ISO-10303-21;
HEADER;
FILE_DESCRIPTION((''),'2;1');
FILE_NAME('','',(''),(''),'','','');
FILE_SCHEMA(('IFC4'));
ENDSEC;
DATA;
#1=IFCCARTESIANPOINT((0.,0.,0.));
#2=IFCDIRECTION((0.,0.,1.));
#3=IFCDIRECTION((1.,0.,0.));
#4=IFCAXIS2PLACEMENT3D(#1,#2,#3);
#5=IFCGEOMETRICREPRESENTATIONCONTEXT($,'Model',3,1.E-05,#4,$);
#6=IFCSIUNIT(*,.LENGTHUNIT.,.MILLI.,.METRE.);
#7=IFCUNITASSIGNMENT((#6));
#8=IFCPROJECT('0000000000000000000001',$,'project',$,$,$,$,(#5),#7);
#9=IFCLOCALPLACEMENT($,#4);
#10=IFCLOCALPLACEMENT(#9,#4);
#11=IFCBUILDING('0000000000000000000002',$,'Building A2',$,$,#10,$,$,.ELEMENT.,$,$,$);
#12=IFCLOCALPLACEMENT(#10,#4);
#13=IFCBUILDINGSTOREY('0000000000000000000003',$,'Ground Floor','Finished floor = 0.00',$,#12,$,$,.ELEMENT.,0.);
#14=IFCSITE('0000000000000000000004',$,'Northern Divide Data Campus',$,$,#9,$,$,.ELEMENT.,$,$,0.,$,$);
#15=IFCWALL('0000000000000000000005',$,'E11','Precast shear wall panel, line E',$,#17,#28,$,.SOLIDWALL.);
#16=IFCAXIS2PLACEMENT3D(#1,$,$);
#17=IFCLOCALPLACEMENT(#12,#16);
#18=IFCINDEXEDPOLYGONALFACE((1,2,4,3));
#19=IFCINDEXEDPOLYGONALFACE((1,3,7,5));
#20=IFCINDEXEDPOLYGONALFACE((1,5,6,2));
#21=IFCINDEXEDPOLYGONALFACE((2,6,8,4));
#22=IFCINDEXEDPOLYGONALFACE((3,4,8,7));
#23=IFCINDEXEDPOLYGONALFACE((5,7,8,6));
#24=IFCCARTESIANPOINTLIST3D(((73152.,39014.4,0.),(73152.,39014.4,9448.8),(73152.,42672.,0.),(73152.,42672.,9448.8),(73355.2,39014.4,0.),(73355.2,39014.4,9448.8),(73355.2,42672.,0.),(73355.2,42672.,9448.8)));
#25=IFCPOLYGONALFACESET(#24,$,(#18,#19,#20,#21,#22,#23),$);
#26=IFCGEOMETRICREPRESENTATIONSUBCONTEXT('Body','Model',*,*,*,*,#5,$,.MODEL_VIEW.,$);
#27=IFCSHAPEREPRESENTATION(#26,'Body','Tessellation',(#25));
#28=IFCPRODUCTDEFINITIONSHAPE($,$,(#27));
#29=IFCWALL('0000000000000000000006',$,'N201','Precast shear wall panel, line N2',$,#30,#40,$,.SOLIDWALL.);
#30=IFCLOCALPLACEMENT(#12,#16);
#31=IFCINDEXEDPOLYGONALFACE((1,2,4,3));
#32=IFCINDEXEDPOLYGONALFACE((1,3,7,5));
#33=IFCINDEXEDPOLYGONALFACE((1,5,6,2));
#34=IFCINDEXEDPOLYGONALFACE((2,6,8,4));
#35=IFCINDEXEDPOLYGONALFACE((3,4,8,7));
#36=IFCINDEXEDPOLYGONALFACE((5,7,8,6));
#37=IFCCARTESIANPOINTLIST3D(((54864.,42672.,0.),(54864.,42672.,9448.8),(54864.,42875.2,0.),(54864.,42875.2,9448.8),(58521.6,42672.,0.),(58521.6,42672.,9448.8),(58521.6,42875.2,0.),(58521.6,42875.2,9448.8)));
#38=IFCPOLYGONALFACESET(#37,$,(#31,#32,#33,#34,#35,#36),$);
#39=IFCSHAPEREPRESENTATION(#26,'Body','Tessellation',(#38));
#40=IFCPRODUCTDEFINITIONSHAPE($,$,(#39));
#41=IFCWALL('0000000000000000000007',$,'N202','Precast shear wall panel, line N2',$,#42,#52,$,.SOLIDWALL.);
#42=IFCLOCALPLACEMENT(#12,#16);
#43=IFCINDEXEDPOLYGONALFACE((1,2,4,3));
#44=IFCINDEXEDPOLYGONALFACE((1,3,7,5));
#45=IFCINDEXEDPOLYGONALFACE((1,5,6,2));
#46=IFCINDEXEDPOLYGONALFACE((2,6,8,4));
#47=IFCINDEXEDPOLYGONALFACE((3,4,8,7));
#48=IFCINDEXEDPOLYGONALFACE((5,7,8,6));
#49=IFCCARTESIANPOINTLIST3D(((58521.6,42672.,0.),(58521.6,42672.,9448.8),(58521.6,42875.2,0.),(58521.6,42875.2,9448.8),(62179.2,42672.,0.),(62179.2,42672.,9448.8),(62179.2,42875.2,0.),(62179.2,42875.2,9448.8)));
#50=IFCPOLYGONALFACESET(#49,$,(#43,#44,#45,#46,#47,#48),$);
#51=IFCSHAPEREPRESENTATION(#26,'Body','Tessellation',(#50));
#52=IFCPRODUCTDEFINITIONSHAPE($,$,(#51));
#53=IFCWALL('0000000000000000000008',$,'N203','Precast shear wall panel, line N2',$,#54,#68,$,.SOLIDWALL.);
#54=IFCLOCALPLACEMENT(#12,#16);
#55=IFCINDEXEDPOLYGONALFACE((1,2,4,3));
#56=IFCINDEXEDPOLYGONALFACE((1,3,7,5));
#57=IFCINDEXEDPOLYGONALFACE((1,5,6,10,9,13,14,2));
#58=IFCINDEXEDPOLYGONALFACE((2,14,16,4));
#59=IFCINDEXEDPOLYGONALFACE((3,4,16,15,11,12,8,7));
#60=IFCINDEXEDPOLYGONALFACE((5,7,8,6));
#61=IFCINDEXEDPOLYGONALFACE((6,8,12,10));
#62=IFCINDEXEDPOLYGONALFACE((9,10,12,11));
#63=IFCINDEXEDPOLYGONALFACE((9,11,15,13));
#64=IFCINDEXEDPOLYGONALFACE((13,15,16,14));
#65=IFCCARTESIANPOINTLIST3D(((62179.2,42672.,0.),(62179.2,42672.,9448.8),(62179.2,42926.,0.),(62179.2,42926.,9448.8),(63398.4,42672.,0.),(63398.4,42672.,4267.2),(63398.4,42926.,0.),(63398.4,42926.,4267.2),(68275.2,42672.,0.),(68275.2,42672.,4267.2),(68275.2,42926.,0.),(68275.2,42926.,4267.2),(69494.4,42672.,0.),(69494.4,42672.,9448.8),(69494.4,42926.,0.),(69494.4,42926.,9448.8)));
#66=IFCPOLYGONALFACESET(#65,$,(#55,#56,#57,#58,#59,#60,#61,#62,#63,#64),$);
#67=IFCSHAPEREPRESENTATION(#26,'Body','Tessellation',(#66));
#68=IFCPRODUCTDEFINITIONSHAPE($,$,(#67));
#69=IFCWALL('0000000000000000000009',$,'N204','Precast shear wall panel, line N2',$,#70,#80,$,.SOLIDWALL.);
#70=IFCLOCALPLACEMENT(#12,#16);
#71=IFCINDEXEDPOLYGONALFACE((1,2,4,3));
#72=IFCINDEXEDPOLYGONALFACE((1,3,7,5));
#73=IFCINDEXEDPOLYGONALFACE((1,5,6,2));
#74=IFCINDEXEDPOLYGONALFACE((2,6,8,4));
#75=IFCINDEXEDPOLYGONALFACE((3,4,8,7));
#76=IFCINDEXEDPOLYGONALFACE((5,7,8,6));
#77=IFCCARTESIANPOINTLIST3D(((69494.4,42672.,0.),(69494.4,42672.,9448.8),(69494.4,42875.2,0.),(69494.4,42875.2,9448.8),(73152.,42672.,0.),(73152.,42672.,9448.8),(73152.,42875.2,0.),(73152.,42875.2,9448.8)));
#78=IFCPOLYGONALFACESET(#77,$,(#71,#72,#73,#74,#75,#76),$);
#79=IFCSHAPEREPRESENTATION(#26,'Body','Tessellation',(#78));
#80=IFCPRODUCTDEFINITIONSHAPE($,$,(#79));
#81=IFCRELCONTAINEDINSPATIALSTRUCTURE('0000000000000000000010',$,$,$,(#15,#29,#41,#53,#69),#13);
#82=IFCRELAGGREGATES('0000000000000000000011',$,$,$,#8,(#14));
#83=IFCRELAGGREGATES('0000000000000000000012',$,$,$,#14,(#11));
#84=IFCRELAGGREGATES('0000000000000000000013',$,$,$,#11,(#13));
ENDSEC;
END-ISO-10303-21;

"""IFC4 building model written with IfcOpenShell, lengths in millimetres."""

from ifc_helpers import new_model, si_unit, origin, origin_with_axes, place, context, subcontext, project, spatial, polyline, outline, extrude, element, save


model = new_model("IFC4")

# Units and contexts
model_context = context("Model", 3, precision=1e-05, world=origin_with_axes())
body_context = subcontext(model_context, "Body", "Model", "MODEL_VIEW")
ifc_project = project(units=[si_unit("LENGTHUNIT", "METRE", prefix="MILLI")], contexts=[model_context])

# Site, building, storey
site_placement = place(None, origin_with_axes())
site = spatial("IfcSite", under=ifc_project, at=site_placement, Name="Northern Divide Data Campus", CompositionType="ELEMENT", RefElevation=0.0)
building_placement = place(site_placement, origin_with_axes())
building = spatial("IfcBuilding", under=site, at=building_placement, Name="Building A2", CompositionType="ELEMENT")
storey_placement = place(building_placement, origin_with_axes())
storey = spatial("IfcBuildingStorey", under=building, at=storey_placement, Name="Ground Floor", Description="Finished floor = 0.00", CompositionType="ELEMENT", Elevation=0.0)

# Walls
wall_1_placement = place(storey_placement, origin_with_axes())
element("IfcWall", 1, at=wall_1_placement, inside=storey, Name="E11", Description="Precast shear wall panel, line E", PredefinedType="SOLIDWALL", context=body_context, shape_type="SweptSolid", body=[
    extrude(outline(polyline([(73152.0, 39014.4), (73355.2, 39014.4), (73355.2, 42672.0), (73152.0, 42672.0), (73152.0, 39014.4)])), origin(), (0.0, 0.0, 1.0), 9448.8),
])
wall_2_placement = place(storey_placement, origin_with_axes())
element("IfcWall", 2, at=wall_2_placement, inside=storey, Name="N201", Description="Precast shear wall panel, line N2", PredefinedType="SOLIDWALL", context=body_context, shape_type="SweptSolid", body=[
    extrude(outline(polyline([(54864.0, 42672.0), (58521.6, 42672.0), (58521.6, 42875.2), (54864.0, 42875.2), (54864.0, 42672.0)])), origin(), (0.0, 0.0, 1.0), 9448.8),
])
wall_3_placement = place(storey_placement, origin_with_axes())
element("IfcWall", 3, at=wall_3_placement, inside=storey, Name="N202", Description="Precast shear wall panel, line N2", PredefinedType="SOLIDWALL", context=body_context, shape_type="SweptSolid", body=[
    extrude(outline(polyline([(58521.6, 42672.0), (62179.2, 42672.0), (62179.2, 42875.2), (58521.6, 42875.2), (58521.6, 42672.0)])), origin(), (0.0, 0.0, 1.0), 9448.8),
])

# Wall, opening
wall_4_placement = place(storey_placement, origin_with_axes())
wall_4 = element("IfcWall", 4, at=wall_4_placement, inside=storey, Name="N203", Description="Precast shear wall panel, line N2", PredefinedType="SOLIDWALL", context=body_context, shape_type="SweptSolid", body=[
    extrude(outline(polyline([(62179.2, 42672.0), (69494.4, 42672.0), (69494.4, 42926.0), (62179.2, 42926.0), (62179.2, 42672.0)])), origin(), (0.0, 0.0, 1.0), 9448.8),
])
opening_1_placement = place(storey_placement, origin_with_axes())
element("IfcOpeningElement", 5, at=opening_1_placement, cuts=wall_4, PredefinedType="OPENING", context=body_context, shape_type="SweptSolid", body=[
    extrude(outline(polyline([(63398.4, 42672.0), (68275.2, 42672.0), (68275.2, 42926.0), (63398.4, 42926.0), (63398.4, 42672.0)])), origin_with_axes(), (0.0, 0.0, 1.0), 4267.2),
])

# Wall
wall_5_placement = place(storey_placement, origin_with_axes())
element("IfcWall", 6, at=wall_5_placement, inside=storey, Name="N204", Description="Precast shear wall panel, line N2", PredefinedType="SOLIDWALL", context=body_context, shape_type="SweptSolid", body=[
    extrude(outline(polyline([(69494.4, 42672.0), (73152.0, 42672.0), (73152.0, 42875.2), (69494.4, 42875.2), (69494.4, 42672.0)])), origin(), (0.0, 0.0, 1.0), 9448.8),
])

save(model, "model.ifc")
